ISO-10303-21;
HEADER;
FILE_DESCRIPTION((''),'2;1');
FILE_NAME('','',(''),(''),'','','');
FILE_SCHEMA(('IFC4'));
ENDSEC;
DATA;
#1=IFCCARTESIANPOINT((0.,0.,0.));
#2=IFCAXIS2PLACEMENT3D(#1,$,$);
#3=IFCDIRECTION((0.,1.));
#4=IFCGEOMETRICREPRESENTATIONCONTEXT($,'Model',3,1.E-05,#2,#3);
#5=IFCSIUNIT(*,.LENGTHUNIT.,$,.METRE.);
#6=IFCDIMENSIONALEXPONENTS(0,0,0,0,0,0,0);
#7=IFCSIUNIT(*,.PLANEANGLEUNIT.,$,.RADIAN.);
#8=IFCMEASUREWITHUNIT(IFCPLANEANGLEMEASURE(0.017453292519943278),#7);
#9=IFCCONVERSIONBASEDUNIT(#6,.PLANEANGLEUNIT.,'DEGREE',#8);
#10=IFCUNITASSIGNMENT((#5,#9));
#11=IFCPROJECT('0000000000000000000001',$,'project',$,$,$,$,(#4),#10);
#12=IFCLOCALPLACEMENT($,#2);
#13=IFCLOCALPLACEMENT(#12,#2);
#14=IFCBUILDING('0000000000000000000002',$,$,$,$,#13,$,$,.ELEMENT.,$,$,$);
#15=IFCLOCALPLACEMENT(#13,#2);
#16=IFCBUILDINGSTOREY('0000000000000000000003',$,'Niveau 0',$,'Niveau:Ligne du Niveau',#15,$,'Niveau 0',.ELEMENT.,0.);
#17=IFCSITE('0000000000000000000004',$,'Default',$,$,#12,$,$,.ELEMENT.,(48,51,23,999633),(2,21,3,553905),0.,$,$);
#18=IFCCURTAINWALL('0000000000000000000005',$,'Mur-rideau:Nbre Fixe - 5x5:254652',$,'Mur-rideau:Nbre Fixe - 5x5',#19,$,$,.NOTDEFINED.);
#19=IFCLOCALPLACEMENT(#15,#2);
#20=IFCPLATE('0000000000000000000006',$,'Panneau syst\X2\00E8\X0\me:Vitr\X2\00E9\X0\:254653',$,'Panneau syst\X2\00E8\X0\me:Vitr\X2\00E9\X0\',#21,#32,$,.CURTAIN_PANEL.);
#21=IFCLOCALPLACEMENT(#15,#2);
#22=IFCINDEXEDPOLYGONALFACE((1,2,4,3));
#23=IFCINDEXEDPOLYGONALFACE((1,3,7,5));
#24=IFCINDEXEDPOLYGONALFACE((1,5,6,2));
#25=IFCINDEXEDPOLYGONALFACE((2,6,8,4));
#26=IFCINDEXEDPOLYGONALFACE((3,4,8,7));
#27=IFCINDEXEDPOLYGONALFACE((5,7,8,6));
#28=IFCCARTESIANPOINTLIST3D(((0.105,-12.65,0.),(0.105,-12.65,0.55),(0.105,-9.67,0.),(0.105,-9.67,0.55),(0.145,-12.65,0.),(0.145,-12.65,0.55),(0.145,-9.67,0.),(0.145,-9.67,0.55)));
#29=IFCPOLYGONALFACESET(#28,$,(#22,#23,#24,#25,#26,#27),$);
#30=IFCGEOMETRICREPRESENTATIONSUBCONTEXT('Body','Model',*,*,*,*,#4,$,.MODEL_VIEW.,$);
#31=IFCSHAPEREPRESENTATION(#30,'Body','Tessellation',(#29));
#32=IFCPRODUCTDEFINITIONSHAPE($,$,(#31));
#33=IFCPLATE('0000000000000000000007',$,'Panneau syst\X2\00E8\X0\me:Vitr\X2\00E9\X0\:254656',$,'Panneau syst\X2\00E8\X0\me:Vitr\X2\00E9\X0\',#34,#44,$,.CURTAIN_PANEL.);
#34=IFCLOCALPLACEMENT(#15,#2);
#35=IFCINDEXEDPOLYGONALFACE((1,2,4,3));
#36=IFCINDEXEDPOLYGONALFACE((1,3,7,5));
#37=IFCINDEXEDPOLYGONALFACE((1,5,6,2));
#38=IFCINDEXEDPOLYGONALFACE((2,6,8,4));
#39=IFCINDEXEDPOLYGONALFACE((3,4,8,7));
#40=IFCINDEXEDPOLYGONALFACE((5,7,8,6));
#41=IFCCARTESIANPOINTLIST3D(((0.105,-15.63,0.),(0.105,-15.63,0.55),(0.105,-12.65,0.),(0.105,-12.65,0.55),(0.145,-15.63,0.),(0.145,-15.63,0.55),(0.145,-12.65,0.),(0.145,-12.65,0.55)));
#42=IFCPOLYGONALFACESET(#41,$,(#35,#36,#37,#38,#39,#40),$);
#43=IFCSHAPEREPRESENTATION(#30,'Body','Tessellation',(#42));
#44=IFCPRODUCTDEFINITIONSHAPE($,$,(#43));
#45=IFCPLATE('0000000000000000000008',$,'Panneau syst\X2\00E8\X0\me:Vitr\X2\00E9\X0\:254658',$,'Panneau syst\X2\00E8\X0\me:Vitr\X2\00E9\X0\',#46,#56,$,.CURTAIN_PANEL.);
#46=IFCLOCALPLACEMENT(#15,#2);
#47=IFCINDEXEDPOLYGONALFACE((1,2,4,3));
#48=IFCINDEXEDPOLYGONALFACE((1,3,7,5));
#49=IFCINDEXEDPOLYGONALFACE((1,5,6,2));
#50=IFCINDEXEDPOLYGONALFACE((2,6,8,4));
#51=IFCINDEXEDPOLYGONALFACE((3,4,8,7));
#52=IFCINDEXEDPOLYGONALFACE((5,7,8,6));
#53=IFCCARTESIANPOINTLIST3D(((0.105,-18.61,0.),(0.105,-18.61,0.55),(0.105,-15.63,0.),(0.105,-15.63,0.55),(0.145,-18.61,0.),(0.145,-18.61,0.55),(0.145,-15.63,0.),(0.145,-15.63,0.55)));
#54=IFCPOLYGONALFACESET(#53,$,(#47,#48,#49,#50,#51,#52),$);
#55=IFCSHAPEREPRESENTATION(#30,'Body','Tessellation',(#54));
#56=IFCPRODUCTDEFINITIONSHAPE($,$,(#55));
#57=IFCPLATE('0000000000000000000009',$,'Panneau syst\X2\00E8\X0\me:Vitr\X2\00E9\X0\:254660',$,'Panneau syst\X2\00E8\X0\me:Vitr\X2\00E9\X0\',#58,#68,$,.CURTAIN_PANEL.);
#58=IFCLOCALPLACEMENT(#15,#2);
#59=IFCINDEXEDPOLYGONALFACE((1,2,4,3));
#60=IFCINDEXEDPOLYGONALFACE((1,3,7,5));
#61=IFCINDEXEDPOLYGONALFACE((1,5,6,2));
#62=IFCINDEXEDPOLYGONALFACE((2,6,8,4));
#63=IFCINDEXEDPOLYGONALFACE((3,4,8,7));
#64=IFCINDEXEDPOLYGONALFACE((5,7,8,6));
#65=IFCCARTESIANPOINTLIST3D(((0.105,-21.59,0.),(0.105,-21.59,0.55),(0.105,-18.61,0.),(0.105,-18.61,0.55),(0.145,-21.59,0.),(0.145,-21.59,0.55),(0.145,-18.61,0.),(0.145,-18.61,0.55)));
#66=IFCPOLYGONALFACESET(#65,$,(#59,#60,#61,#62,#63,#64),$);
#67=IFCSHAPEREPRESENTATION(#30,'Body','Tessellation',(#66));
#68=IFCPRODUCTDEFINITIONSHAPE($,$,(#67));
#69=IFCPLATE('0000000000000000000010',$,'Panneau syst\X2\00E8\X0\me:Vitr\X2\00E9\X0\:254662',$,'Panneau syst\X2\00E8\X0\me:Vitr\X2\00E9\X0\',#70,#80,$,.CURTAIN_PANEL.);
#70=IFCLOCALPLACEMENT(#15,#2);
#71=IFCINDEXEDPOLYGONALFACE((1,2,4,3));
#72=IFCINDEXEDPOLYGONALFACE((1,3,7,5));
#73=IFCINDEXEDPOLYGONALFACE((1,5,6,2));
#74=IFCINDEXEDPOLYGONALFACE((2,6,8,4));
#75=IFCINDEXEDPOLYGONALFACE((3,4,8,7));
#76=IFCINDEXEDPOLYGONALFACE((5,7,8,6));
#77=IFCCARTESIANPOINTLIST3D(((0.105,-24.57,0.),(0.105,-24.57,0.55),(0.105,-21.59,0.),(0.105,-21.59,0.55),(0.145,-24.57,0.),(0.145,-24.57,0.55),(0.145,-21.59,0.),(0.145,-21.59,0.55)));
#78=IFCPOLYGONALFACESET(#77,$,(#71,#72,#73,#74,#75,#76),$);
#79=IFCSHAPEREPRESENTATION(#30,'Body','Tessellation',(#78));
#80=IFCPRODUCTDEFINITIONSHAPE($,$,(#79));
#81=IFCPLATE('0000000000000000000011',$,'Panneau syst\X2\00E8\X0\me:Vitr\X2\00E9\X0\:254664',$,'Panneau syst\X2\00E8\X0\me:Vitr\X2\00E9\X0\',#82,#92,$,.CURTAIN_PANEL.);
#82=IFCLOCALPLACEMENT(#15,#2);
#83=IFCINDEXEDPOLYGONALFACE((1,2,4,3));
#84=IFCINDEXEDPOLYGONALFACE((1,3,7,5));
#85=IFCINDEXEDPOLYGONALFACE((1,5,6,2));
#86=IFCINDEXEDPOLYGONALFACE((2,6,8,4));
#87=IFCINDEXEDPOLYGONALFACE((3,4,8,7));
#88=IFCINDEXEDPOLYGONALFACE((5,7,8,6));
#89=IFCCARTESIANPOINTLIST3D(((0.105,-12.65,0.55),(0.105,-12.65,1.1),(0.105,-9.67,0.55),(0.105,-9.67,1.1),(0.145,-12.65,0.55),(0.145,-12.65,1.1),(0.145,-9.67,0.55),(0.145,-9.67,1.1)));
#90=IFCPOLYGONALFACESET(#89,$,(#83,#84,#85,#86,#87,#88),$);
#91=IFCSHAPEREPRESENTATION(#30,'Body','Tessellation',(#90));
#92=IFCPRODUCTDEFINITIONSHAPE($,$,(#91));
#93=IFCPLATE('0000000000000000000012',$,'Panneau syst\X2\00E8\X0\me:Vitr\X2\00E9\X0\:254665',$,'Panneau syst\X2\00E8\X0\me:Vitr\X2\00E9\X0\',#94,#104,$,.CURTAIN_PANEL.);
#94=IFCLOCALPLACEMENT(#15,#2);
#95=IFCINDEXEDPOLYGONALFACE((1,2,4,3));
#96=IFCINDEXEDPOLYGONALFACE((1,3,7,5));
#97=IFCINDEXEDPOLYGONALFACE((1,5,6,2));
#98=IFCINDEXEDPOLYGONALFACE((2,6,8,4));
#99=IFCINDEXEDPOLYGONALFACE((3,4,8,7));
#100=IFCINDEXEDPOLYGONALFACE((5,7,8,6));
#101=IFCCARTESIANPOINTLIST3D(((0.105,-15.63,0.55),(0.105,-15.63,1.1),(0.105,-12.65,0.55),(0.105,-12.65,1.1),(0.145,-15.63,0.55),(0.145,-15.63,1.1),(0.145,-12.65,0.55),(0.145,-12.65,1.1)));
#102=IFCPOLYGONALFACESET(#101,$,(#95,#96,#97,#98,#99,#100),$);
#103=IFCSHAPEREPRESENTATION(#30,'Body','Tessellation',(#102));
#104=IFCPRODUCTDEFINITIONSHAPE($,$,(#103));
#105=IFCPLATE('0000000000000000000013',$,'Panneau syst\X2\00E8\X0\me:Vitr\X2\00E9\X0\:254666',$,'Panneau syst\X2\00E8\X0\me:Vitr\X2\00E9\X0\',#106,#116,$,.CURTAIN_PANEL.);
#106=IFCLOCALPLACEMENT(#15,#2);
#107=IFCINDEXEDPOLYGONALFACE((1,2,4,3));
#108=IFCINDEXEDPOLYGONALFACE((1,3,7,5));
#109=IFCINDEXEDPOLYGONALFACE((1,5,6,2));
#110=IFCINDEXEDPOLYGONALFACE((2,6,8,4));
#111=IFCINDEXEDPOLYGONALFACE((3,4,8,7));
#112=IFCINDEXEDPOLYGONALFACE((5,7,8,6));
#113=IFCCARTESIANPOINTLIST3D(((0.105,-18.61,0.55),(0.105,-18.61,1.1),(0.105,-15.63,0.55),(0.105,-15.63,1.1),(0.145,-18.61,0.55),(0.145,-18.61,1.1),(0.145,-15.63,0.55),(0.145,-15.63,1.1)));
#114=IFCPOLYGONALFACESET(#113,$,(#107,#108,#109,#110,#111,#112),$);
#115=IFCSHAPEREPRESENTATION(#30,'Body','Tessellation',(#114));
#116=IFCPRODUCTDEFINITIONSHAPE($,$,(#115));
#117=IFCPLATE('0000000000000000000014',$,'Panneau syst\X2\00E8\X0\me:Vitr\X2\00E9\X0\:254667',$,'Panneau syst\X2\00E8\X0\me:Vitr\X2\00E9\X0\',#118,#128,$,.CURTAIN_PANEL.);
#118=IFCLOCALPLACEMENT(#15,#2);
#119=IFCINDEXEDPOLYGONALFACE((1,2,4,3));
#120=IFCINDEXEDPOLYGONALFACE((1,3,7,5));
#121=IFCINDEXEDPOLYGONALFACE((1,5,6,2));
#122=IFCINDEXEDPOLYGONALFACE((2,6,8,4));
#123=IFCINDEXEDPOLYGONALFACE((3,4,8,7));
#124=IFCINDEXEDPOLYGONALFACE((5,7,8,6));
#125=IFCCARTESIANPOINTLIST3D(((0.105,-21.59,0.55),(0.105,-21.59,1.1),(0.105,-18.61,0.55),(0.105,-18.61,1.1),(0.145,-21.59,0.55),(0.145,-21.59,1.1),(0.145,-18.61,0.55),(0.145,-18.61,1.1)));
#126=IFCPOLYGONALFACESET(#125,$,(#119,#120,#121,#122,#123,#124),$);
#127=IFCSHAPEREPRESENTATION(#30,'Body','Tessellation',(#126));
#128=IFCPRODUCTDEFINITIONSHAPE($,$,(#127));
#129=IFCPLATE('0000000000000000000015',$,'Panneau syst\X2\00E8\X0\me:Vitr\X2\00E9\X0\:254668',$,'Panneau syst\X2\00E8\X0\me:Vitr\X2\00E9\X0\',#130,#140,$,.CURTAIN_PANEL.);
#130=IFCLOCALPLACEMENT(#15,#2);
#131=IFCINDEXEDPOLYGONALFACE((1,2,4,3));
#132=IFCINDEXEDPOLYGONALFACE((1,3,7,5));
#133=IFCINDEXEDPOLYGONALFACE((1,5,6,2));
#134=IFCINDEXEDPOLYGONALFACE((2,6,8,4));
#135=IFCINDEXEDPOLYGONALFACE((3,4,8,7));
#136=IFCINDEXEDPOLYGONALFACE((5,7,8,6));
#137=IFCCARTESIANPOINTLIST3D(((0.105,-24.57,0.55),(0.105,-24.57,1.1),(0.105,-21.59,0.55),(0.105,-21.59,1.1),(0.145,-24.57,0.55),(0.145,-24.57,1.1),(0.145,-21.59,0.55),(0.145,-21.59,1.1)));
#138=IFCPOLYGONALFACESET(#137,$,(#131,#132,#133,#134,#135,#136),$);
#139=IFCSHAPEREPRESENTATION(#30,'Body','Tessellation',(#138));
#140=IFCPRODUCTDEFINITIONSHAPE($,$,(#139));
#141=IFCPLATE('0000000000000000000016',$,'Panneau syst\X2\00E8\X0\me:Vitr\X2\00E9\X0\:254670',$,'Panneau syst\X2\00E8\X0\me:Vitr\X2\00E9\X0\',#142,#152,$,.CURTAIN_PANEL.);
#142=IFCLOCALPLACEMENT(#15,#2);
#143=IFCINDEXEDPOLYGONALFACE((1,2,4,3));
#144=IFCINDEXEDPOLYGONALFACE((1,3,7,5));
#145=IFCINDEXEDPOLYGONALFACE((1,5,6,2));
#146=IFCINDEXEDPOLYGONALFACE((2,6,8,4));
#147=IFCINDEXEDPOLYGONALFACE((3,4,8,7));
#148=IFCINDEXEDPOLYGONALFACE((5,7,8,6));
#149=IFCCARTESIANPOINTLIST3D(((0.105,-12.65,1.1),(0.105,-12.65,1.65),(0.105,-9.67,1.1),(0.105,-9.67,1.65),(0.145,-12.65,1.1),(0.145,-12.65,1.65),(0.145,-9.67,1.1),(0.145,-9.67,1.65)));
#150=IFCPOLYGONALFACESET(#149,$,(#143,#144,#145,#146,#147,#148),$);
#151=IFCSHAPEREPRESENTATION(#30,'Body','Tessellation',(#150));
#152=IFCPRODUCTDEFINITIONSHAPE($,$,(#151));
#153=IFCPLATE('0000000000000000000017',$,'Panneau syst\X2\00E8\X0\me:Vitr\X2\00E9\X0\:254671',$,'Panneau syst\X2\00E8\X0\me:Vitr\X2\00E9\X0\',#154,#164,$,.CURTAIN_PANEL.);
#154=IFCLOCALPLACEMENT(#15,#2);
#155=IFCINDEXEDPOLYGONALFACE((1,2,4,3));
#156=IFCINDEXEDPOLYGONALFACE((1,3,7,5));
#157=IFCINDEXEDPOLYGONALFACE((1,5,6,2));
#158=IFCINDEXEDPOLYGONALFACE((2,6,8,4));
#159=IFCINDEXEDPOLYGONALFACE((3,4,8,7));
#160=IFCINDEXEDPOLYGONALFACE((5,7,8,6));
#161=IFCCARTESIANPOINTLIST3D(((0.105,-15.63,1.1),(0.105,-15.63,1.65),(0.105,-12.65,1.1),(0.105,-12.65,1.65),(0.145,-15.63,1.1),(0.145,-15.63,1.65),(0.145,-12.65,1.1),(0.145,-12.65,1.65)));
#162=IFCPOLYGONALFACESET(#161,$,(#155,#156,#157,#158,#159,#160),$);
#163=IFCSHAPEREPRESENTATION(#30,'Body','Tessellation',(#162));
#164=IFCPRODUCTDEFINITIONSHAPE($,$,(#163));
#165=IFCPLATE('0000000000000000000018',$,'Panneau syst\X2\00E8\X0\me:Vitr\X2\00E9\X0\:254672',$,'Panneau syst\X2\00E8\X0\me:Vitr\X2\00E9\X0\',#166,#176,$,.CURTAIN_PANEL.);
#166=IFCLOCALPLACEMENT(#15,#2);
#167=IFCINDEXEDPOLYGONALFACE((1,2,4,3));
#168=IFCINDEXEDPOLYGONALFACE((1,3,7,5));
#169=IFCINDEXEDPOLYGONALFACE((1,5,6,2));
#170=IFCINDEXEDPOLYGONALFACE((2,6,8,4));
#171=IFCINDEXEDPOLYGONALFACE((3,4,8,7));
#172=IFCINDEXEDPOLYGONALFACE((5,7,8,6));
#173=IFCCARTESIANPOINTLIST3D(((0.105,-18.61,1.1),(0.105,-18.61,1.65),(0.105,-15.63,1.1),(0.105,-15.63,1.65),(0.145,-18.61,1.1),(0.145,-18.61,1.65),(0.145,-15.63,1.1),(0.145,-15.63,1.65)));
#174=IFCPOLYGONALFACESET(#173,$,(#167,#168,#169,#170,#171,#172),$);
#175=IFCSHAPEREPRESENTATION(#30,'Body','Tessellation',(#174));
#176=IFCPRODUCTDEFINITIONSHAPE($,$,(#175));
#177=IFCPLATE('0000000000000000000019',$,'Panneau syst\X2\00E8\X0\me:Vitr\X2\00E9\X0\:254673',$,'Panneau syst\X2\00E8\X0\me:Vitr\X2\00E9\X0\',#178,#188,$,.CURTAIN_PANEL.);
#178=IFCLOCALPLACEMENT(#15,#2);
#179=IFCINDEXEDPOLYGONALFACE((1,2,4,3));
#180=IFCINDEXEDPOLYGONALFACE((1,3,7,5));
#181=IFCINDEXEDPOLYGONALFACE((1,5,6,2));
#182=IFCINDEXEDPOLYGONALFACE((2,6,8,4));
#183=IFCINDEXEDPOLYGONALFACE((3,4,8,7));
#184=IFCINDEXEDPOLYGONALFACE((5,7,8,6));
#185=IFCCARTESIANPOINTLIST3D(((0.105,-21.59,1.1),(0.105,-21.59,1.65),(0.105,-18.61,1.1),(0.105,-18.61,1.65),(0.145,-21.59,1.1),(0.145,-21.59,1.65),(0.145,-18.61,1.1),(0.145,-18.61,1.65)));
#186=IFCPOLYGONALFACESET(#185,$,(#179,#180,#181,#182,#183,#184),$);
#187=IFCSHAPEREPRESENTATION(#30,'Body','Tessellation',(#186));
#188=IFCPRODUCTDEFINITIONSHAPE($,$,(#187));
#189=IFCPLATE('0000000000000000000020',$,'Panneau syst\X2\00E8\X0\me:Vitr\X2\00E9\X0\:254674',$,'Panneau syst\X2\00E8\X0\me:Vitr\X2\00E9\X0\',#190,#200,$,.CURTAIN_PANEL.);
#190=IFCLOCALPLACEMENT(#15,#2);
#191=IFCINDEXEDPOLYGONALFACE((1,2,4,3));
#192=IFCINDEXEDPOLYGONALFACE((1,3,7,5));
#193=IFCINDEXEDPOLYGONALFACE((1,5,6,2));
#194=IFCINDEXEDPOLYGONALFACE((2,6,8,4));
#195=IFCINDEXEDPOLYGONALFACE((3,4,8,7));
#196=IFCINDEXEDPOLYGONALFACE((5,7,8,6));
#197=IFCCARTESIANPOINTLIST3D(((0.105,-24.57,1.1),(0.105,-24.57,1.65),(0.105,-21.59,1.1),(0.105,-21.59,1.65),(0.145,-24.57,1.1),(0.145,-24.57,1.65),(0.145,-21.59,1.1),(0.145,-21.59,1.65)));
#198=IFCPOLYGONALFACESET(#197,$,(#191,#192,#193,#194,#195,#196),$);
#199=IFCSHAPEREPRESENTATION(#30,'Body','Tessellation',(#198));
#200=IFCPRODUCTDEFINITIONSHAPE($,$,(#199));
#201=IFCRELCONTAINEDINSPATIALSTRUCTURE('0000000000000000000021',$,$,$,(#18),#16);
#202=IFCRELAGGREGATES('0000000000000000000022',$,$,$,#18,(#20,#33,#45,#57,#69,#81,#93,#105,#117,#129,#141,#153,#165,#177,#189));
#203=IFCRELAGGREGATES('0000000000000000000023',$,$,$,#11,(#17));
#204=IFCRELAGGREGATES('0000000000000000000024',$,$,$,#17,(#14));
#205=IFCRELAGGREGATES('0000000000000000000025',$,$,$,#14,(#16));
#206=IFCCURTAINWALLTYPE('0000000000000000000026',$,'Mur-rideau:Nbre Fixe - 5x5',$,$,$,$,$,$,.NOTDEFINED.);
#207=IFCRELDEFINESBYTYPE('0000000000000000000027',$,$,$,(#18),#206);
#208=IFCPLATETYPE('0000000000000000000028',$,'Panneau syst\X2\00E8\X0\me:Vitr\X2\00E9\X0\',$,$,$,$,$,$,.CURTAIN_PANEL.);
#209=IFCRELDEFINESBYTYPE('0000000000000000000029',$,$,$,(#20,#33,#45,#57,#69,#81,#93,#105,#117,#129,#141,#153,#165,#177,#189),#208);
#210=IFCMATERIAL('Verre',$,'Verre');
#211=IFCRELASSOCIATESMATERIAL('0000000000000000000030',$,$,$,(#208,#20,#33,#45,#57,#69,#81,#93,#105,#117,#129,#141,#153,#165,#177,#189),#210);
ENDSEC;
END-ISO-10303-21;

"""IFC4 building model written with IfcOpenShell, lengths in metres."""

from ifc_helpers import new_model, entity, si_unit, converted_unit, direction, frame, origin, place, context, subcontext, project, spatial, indexed_curve, outline, extrude, source, transform, mapped, material, type_object, type_shapes, element, aggregate, save


model = new_model("IFC4")

# Units and contexts
model_context = context("Model", 3, precision=1e-05, world=origin(), true_north=direction((0.0, 1.0)))
body_context = subcontext(model_context, "Body", "Model", "MODEL_VIEW")
ifc_project = project(units=[si_unit("LENGTHUNIT", "METRE"), converted_unit("PLANEANGLEUNIT", "DEGREE", entity("IfcPlaneAngleMeasure", 0.017453292519943278), si_unit("PLANEANGLEUNIT", "RADIAN"), dimensions=[0, 0, 0, 0, 0, 0, 0])], contexts=[model_context])

# Site, building, storey
site_placement = place(None, origin())
site = spatial("IfcSite", under=ifc_project, at=site_placement, Name="Default", CompositionType="ELEMENT", RefLatitude=(48, 51, 23, 999633), RefLongitude=(2, 21, 3, 553905), RefElevation=0.0)
building_placement = place(site_placement, origin())
building = spatial("IfcBuilding", under=site, at=building_placement, CompositionType="ELEMENT")
storey_placement = place(building_placement, origin())
storey = spatial("IfcBuildingStorey", under=building, at=storey_placement, Name="Niveau 0", ObjectType="Niveau:Ligne du Niveau", LongName="Niveau 0", CompositionType="ELEMENT", Elevation=0.0)

# Curtain wall, plates
curtain_wall_type = type_object("IfcCurtainWallType", Name="Mur-rideau:Nbre Fixe - 5x5", PredefinedType="NOTDEFINED")
curtain_wall_placement = place(storey_placement, origin())
curtain_wall = element("IfcCurtainWall", 1, at=curtain_wall_placement, inside=storey, type_object=curtain_wall_type, Name="Mur-rideau:Nbre Fixe - 5x5:254652", ObjectType="Mur-rideau:Nbre Fixe - 5x5", PredefinedType="NOTDEFINED")
ifc_material = material(Name="Verre", Category="Verre")
plate_type = type_object("IfcPlateType", Name="Panneau système:Vitré", PredefinedType="CURTAIN_PANEL", material=ifc_material)
shared_shape = source(origin(), body_context, "Body", "SweptSolid", [
    extrude(outline(indexed_curve([(-0.02, -1.49), (0.02, -1.49), (0.02, 1.49), (-0.02, 1.49), (-0.02, -1.49)], self_intersect=False)), frame((1.49, 0.02, 0.0), z_axis=(0.0, 0.0, 1.0), x_axis=(0.0, 1.0, 0.0)), (0.0, 0.0, 1.0), 0.55),
])
type_shapes(plate_type, [shared_shape])
plate_1_placement = place(curtain_wall_placement, frame((0.105, -9.67, 0.0), z_axis=(0.0, 0.0, 1.0), x_axis=(0.0, -1.0, 0.0)))
plate_1 = element("IfcPlate", 2, at=plate_1_placement, type_object=plate_type, material=ifc_material, Name="Panneau système:Vitré:254653", ObjectType="Panneau système:Vitré", PredefinedType="CURTAIN_PANEL", context=body_context, shape_type="MappedRepresentation", body=[
    mapped(shared_shape, transform((0.0, 0.0, 0.0), scale=1.0)),
])
plate_2_placement = place(curtain_wall_placement, frame((0.105, -12.65, 0.0), z_axis=(0.0, 0.0, 1.0), x_axis=(0.0, -1.0, 0.0)))
plate_2 = element("IfcPlate", 3, at=plate_2_placement, type_object=plate_type, material=ifc_material, Name="Panneau système:Vitré:254656", ObjectType="Panneau système:Vitré", PredefinedType="CURTAIN_PANEL", context=body_context, shape_type="MappedRepresentation", body=[
    mapped(shared_shape, transform((0.0, 0.0, 0.0), scale=1.0)),
])
plate_3_placement = place(curtain_wall_placement, frame((0.105, -15.63, 0.0), z_axis=(0.0, 0.0, 1.0), x_axis=(0.0, -1.0, 0.0)))
plate_3 = element("IfcPlate", 4, at=plate_3_placement, type_object=plate_type, material=ifc_material, Name="Panneau système:Vitré:254658", ObjectType="Panneau système:Vitré", PredefinedType="CURTAIN_PANEL", context=body_context, shape_type="MappedRepresentation", body=[
    mapped(shared_shape, transform((0.0, 0.0, 0.0), scale=1.0)),
])
plate_4_placement = place(curtain_wall_placement, frame((0.105, -18.61, 0.0), z_axis=(0.0, 0.0, 1.0), x_axis=(0.0, -1.0, 0.0)))
plate_4 = element("IfcPlate", 5, at=plate_4_placement, type_object=plate_type, material=ifc_material, Name="Panneau système:Vitré:254660", ObjectType="Panneau système:Vitré", PredefinedType="CURTAIN_PANEL", context=body_context, shape_type="MappedRepresentation", body=[
    mapped(shared_shape, transform((0.0, 0.0, 0.0), scale=1.0)),
])
plate_5_placement = place(curtain_wall_placement, frame((0.105, -21.59, 0.0), z_axis=(0.0, 0.0, 1.0), x_axis=(0.0, -1.0, 0.0)))
plate_5 = element("IfcPlate", 6, at=plate_5_placement, type_object=plate_type, material=ifc_material, Name="Panneau système:Vitré:254662", ObjectType="Panneau système:Vitré", PredefinedType="CURTAIN_PANEL", context=body_context, shape_type="MappedRepresentation", body=[
    mapped(shared_shape, transform((0.0, 0.0, 0.0), scale=1.0)),
])
plate_6_placement = place(curtain_wall_placement, frame((0.105, -9.67, 0.55), z_axis=(0.0, 0.0, 1.0), x_axis=(0.0, -1.0, 0.0)))
plate_6 = element("IfcPlate", 7, at=plate_6_placement, type_object=plate_type, material=ifc_material, Name="Panneau système:Vitré:254664", ObjectType="Panneau système:Vitré", PredefinedType="CURTAIN_PANEL", context=body_context, shape_type="MappedRepresentation", body=[
    mapped(shared_shape, transform((0.0, 0.0, 0.0), scale=1.0)),
])
plate_7_placement = place(curtain_wall_placement, frame((0.105, -12.65, 0.55), z_axis=(0.0, 0.0, 1.0), x_axis=(0.0, -1.0, 0.0)))
plate_7 = element("IfcPlate", 8, at=plate_7_placement, type_object=plate_type, material=ifc_material, Name="Panneau système:Vitré:254665", ObjectType="Panneau système:Vitré", PredefinedType="CURTAIN_PANEL", context=body_context, shape_type="MappedRepresentation", body=[
    mapped(shared_shape, transform((0.0, 0.0, 0.0), scale=1.0)),
])
plate_8_placement = place(curtain_wall_placement, frame((0.105, -15.63, 0.55), z_axis=(0.0, 0.0, 1.0), x_axis=(0.0, -1.0, 0.0)))
plate_8 = element("IfcPlate", 9, at=plate_8_placement, type_object=plate_type, material=ifc_material, Name="Panneau système:Vitré:254666", ObjectType="Panneau système:Vitré", PredefinedType="CURTAIN_PANEL", context=body_context, shape_type="MappedRepresentation", body=[
    mapped(shared_shape, transform((0.0, 0.0, 0.0), scale=1.0)),
])
plate_9_placement = place(curtain_wall_placement, frame((0.105, -18.61, 0.55), z_axis=(0.0, 0.0, 1.0), x_axis=(0.0, -1.0, 0.0)))
plate_9 = element("IfcPlate", 10, at=plate_9_placement, type_object=plate_type, material=ifc_material, Name="Panneau système:Vitré:254667", ObjectType="Panneau système:Vitré", PredefinedType="CURTAIN_PANEL", context=body_context, shape_type="MappedRepresentation", body=[
    mapped(shared_shape, transform((0.0, 0.0, 0.0), scale=1.0)),
])
plate_10_placement = place(curtain_wall_placement, frame((0.105, -21.59, 0.55), z_axis=(0.0, 0.0, 1.0), x_axis=(0.0, -1.0, 0.0)))
plate_10 = element("IfcPlate", 11, at=plate_10_placement, type_object=plate_type, material=ifc_material, Name="Panneau système:Vitré:254668", ObjectType="Panneau système:Vitré", PredefinedType="CURTAIN_PANEL", context=body_context, shape_type="MappedRepresentation", body=[
    mapped(shared_shape, transform((0.0, 0.0, 0.0), scale=1.0)),
])
plate_11_placement = place(curtain_wall_placement, frame((0.105, -9.67, 1.1), z_axis=(0.0, 0.0, 1.0), x_axis=(0.0, -1.0, 0.0)))
plate_11 = element("IfcPlate", 12, at=plate_11_placement, type_object=plate_type, material=ifc_material, Name="Panneau système:Vitré:254670", ObjectType="Panneau système:Vitré", PredefinedType="CURTAIN_PANEL", context=body_context, shape_type="MappedRepresentation", body=[
    mapped(shared_shape, transform((0.0, 0.0, 0.0), scale=1.0)),
])
plate_12_placement = place(curtain_wall_placement, frame((0.105, -12.65, 1.1), z_axis=(0.0, 0.0, 1.0), x_axis=(0.0, -1.0, 0.0)))
plate_12 = element("IfcPlate", 13, at=plate_12_placement, type_object=plate_type, material=ifc_material, Name="Panneau système:Vitré:254671", ObjectType="Panneau système:Vitré", PredefinedType="CURTAIN_PANEL", context=body_context, shape_type="MappedRepresentation", body=[
    mapped(shared_shape, transform((0.0, 0.0, 0.0), scale=1.0)),
])
plate_13_placement = place(curtain_wall_placement, frame((0.105, -15.63, 1.1), z_axis=(0.0, 0.0, 1.0), x_axis=(0.0, -1.0, 0.0)))
plate_13 = element("IfcPlate", 14, at=plate_13_placement, type_object=plate_type, material=ifc_material, Name="Panneau système:Vitré:254672", ObjectType="Panneau système:Vitré", PredefinedType="CURTAIN_PANEL", context=body_context, shape_type="MappedRepresentation", body=[
    mapped(shared_shape, transform((0.0, 0.0, 0.0), scale=1.0)),
])
plate_14_placement = place(curtain_wall_placement, frame((0.105, -18.61, 1.1), z_axis=(0.0, 0.0, 1.0), x_axis=(0.0, -1.0, 0.0)))
plate_14 = element("IfcPlate", 15, at=plate_14_placement, type_object=plate_type, material=ifc_material, Name="Panneau système:Vitré:254673", ObjectType="Panneau système:Vitré", PredefinedType="CURTAIN_PANEL", context=body_context, shape_type="MappedRepresentation", body=[
    mapped(shared_shape, transform((0.0, 0.0, 0.0), scale=1.0)),
])
plate_15_placement = place(curtain_wall_placement, frame((0.105, -21.59, 1.1), z_axis=(0.0, 0.0, 1.0), x_axis=(0.0, -1.0, 0.0)))
plate_15 = element("IfcPlate", 16, at=plate_15_placement, type_object=plate_type, material=ifc_material, Name="Panneau système:Vitré:254674", ObjectType="Panneau système:Vitré", PredefinedType="CURTAIN_PANEL", context=body_context, shape_type="MappedRepresentation", body=[
    mapped(shared_shape, transform((0.0, 0.0, 0.0), scale=1.0)),
])
aggregate(curtain_wall, [plate_1, plate_2, plate_3, plate_4, plate_5, plate_6, plate_7, plate_8, plate_9, plate_10, plate_11, plate_12, plate_13, plate_14, plate_15])

save(model, "model.ifc")
